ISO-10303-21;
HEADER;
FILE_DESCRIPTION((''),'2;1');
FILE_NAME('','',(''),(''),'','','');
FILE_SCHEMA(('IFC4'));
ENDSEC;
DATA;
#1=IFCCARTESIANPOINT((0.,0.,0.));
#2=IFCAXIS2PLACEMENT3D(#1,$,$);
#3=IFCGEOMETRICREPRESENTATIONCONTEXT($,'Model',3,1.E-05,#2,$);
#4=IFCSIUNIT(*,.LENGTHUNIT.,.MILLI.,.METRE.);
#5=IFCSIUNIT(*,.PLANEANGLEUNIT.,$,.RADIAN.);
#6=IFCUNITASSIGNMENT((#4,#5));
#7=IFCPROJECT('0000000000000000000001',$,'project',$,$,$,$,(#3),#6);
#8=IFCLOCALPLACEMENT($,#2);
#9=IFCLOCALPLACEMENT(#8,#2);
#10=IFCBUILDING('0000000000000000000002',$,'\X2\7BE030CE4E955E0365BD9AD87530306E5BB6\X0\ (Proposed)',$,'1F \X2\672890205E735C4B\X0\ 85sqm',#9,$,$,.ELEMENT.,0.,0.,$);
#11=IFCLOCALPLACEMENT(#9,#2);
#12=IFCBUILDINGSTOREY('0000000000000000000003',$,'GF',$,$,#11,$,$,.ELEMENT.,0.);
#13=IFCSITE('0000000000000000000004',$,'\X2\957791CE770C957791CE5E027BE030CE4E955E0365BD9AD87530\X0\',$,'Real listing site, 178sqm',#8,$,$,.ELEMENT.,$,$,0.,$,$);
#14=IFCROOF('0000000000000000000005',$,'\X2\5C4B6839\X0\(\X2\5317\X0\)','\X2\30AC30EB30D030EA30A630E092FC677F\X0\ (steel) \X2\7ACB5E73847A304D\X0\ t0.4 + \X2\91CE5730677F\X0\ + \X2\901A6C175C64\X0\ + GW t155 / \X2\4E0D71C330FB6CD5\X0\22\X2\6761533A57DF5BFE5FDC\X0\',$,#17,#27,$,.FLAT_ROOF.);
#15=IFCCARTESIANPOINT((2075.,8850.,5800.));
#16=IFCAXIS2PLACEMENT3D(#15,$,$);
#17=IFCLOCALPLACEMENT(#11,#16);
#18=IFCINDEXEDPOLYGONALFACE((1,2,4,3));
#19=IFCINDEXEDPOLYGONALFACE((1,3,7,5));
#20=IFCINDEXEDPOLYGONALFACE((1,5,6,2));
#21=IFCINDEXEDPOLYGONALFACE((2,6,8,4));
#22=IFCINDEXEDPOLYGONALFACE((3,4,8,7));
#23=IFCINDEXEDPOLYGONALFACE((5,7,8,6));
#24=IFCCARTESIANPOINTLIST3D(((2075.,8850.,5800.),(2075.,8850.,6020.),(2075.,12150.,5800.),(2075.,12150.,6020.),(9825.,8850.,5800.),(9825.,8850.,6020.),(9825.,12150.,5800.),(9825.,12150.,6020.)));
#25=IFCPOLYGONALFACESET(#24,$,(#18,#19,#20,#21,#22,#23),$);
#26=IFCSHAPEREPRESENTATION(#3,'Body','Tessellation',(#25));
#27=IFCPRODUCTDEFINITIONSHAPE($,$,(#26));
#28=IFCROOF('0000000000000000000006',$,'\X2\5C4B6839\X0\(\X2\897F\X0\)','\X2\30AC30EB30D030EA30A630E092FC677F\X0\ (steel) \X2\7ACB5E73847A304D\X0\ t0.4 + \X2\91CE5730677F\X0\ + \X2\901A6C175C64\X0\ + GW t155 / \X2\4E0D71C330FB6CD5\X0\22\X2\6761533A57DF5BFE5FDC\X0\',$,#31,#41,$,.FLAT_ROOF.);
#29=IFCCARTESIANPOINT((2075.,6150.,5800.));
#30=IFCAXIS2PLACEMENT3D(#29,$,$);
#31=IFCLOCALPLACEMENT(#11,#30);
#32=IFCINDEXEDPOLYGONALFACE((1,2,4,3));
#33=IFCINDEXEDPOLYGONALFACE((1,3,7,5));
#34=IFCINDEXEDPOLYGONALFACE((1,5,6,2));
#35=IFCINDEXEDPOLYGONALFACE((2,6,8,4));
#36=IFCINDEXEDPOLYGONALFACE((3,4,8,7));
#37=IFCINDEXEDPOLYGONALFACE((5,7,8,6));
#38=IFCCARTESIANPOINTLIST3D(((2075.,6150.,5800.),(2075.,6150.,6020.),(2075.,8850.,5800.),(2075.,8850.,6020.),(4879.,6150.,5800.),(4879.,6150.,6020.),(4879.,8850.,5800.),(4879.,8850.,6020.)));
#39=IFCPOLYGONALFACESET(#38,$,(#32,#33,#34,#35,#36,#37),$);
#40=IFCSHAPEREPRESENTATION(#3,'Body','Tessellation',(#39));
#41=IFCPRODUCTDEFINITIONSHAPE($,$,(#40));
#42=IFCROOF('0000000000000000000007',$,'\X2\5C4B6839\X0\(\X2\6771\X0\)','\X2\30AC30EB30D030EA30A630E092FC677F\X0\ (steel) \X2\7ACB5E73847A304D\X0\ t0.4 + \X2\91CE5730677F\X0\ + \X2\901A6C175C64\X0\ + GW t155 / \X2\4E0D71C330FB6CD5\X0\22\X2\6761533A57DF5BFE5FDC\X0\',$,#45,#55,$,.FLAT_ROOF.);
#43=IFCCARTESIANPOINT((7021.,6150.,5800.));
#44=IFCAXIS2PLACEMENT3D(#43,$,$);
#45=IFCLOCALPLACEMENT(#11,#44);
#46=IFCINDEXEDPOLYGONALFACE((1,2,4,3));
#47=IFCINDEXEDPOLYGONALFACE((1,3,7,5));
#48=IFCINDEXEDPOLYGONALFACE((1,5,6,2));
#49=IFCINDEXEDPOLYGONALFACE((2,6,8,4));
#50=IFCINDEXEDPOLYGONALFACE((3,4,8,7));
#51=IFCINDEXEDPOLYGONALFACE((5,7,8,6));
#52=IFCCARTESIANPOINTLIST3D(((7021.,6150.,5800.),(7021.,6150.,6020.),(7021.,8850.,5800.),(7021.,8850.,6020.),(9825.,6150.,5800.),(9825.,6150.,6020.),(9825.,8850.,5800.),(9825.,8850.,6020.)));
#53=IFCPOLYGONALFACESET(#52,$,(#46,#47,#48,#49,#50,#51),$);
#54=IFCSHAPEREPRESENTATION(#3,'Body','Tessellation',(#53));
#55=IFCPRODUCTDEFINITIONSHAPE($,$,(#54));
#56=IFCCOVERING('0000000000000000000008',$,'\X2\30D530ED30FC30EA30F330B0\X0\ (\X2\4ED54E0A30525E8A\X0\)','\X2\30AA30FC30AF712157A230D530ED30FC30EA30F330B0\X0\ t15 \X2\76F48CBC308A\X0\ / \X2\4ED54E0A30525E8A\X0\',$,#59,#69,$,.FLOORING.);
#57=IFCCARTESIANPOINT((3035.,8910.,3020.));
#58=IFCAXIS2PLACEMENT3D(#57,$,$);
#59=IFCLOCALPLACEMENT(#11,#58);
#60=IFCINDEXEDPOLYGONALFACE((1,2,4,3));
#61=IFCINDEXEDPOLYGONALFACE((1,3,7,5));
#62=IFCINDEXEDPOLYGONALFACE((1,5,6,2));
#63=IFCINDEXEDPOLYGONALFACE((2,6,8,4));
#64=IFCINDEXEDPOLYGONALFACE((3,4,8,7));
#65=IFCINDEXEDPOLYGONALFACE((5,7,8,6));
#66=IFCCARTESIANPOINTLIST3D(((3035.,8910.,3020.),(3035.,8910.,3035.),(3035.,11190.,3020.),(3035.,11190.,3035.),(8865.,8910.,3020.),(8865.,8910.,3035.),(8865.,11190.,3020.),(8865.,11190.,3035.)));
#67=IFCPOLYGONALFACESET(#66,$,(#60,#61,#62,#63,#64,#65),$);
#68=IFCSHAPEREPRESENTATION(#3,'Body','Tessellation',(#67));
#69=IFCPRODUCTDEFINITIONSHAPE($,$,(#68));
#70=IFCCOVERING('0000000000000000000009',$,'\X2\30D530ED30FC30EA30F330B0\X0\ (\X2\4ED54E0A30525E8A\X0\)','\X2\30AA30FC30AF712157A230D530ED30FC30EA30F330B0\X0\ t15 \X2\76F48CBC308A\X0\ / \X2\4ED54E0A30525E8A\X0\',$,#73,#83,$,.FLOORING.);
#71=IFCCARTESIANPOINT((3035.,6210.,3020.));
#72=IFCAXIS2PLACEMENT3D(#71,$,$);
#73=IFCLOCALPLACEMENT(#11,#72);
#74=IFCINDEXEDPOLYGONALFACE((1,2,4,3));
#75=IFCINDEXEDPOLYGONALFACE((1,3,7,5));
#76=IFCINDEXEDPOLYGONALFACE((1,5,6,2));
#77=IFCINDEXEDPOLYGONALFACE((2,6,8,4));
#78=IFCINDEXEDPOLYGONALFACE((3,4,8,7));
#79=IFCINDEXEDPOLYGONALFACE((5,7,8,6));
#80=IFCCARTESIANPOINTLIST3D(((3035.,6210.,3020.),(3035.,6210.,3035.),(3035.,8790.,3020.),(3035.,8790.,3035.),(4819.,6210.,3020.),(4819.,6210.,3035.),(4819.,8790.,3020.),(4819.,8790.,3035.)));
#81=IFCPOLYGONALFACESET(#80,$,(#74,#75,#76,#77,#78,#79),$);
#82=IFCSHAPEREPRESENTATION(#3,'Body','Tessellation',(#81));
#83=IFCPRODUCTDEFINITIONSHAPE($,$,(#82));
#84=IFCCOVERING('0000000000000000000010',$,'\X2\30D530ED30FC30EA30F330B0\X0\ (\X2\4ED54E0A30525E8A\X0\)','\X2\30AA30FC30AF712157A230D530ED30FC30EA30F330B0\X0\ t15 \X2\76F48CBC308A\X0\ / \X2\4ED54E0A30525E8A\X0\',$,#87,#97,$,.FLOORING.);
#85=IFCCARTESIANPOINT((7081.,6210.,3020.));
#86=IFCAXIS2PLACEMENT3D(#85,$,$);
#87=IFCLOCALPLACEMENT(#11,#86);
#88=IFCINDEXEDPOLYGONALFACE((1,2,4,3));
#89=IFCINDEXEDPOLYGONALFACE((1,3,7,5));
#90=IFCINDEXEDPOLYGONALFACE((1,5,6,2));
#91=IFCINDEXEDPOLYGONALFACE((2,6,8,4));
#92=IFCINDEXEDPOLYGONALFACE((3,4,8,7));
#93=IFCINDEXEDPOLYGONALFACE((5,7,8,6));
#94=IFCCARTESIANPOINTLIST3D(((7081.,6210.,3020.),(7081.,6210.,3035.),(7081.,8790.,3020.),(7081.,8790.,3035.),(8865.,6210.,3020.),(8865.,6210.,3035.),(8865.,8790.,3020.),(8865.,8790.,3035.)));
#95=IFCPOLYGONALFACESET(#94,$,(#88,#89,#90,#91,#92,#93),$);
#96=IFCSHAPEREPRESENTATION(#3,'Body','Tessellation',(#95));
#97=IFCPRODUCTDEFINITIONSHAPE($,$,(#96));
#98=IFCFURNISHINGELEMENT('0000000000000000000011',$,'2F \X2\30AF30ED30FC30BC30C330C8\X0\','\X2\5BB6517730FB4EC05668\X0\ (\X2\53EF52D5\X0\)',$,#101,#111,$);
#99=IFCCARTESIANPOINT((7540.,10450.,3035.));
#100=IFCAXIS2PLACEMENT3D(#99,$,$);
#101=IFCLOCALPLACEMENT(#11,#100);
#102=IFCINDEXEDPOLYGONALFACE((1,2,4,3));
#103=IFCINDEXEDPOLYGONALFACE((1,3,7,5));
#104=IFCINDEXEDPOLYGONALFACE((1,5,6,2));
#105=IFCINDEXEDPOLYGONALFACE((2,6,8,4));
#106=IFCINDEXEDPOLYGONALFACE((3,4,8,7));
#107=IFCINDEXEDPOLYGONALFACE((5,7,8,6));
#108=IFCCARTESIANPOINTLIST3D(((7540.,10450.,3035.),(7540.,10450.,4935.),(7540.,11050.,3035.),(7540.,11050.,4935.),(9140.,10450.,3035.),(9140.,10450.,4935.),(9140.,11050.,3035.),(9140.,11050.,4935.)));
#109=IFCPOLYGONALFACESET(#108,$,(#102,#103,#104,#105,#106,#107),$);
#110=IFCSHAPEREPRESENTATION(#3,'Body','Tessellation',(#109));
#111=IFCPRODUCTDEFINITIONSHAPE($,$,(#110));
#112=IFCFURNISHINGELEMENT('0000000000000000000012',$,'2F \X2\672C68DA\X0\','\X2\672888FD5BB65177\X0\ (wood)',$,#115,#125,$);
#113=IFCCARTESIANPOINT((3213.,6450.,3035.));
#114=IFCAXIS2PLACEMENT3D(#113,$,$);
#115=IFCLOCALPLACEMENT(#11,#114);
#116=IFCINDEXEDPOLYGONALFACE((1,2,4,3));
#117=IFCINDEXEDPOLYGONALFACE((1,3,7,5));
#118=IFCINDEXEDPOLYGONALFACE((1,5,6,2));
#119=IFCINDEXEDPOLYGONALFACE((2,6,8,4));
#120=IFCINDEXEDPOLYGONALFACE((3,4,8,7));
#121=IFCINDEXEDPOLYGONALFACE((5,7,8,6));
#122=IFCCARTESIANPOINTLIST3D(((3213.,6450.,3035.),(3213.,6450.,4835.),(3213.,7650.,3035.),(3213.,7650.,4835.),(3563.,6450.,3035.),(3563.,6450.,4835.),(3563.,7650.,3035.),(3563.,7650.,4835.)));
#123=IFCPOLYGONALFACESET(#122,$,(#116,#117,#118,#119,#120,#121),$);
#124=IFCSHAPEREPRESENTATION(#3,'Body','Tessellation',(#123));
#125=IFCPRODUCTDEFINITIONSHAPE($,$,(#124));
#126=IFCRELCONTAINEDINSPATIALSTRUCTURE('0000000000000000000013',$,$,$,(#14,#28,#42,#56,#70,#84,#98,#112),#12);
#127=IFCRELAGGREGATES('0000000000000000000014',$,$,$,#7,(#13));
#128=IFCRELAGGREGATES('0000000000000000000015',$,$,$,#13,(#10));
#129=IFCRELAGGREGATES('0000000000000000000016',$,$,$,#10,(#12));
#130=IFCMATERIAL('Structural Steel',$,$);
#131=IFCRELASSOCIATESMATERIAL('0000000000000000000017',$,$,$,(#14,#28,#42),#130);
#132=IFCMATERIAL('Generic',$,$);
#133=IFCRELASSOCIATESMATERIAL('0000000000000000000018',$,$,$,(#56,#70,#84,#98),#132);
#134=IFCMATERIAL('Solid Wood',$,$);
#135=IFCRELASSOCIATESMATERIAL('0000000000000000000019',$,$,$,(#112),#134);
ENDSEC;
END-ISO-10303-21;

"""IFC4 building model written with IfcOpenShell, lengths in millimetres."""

from ifc_helpers import new_model, si_unit, frame, frame_2d, origin, place, context, project, spatial, rectangle, extrude, material, element, save


model = new_model("IFC4")

# Units and contexts
model_context = context("Model", 3, precision=1e-05, world=origin())
ifc_project = project(units=[si_unit("LENGTHUNIT", "METRE", prefix="MILLI"), si_unit("PLANEANGLEUNIT", "RADIAN")], contexts=[model_context])

# Site, building, storey
site_placement = place(None, origin())
site = spatial("IfcSite", under=ifc_project, at=site_placement, Name="長野県長野市篠ノ井布施高田", ObjectType="Real listing site, 178sqm", CompositionType="ELEMENT", RefElevation=0.0)
building_placement = place(site_placement, origin())
building = spatial("IfcBuilding", under=site, at=building_placement, Name="篠ノ井布施高田の家 (Proposed)", ObjectType="1F 木造平屋 85sqm", CompositionType="ELEMENT", ElevationOfRefHeight=0.0, ElevationOfTerrain=0.0)
storey_placement = place(building_placement, origin())
storey = spatial("IfcBuildingStorey", under=building, at=storey_placement, Name="GF", CompositionType="ELEMENT", Elevation=0.0)

# Shared definitions
ifc_material_1 = material(Name="Solid Wood")

# Shared definitions
ifc_material_2 = material(Name="Generic")

# Roofs
ifc_material_3 = material(Name="Structural Steel")
for number, where, name in (
    (1, (2075.0, 8850.0, 5800.0), "屋根(北)"),
):
    element("IfcRoof", number, at=place(storey_placement, frame(where)), inside=storey, material=ifc_material_3, Name=name, Description="ガルバリウム鋼板 (steel) 立平葺き t0.4 + 野地板 + 通気層 + GW t155 / 不燃・法22条区域対応", PredefinedType="FLAT_ROOF", context=model_context, shape_type="SweptSolid", body=[
        extrude(rectangle(XDim=7750.0, YDim=3300.0, at=frame_2d((3875.0, 1650.0))), frame((2075.0, 8850.0, 5800.0)), (0.0, 0.0, 1.0), 220.0),
    ])
roof_1_placement = place(storey_placement, frame((2075.0, 6150.0, 5800.0)))
element("IfcRoof", 2, at=roof_1_placement, inside=storey, material=ifc_material_3, Name="屋根(西)", Description="ガルバリウム鋼板 (steel) 立平葺き t0.4 + 野地板 + 通気層 + GW t155 / 不燃・法22条区域対応", PredefinedType="FLAT_ROOF", context=model_context, shape_type="SweptSolid", body=[
    extrude(rectangle(XDim=2804.0, YDim=2700.0, at=frame_2d((1402.0, 1350.0))), frame((2075.0, 6150.0, 5800.0)), (0.0, 0.0, 1.0), 220.0),
])
roof_2_placement = place(storey_placement, frame((7021.0, 6150.0, 5800.0)))
element("IfcRoof", 3, at=roof_2_placement, inside=storey, material=ifc_material_3, Name="屋根(東)", Description="ガルバリウム鋼板 (steel) 立平葺き t0.4 + 野地板 + 通気層 + GW t155 / 不燃・法22条区域対応", PredefinedType="FLAT_ROOF", context=model_context, shape_type="SweptSolid", body=[
    extrude(rectangle(XDim=2804.0, YDim=2700.0, at=frame_2d((1402.0, 1350.0))), frame((7021.0, 6150.0, 5800.0)), (0.0, 0.0, 1.0), 220.0),
])

# Coverings
covering_1_placement = place(storey_placement, frame((3035.0, 8910.0, 3020.0)))
element("IfcCovering", 4, at=covering_1_placement, inside=storey, material=ifc_material_2, Name="フローリング (仕上げ床)", Description="オーク無垢フローリング t15 直貼り / 仕上げ床", PredefinedType="FLOORING", context=model_context, shape_type="SweptSolid", body=[
    extrude(rectangle(XDim=5830.0, YDim=2280.0, at=frame_2d((2915.0, 1140.0))), frame((3035.0, 8910.0, 3020.0)), (0.0, 0.0, 1.0), 15.0),
])
covering_2_placement = place(storey_placement, frame((3035.0, 6210.0, 3020.0)))
element("IfcCovering", 5, at=covering_2_placement, inside=storey, material=ifc_material_2, Name="フローリング (仕上げ床)", Description="オーク無垢フローリング t15 直貼り / 仕上げ床", PredefinedType="FLOORING", context=model_context, shape_type="SweptSolid", body=[
    extrude(rectangle(XDim=1784.0, YDim=2580.0, at=frame_2d((892.0, 1290.0))), frame((3035.0, 6210.0, 3020.0)), (0.0, 0.0, 1.0), 15.0),
])
covering_3_placement = place(storey_placement, frame((7081.0, 6210.0, 3020.0)))
element("IfcCovering", 6, at=covering_3_placement, inside=storey, material=ifc_material_2, Name="フローリング (仕上げ床)", Description="オーク無垢フローリング t15 直貼り / 仕上げ床", PredefinedType="FLOORING", context=model_context, shape_type="SweptSolid", body=[
    extrude(rectangle(XDim=1784.0, YDim=2580.0, at=frame_2d((892.0, 1290.0))), frame((7081.0, 6210.0, 3020.0)), (0.0, 0.0, 1.0), 15.0),
])

# Furnishing elements
furnishing_1_placement = place(storey_placement, frame((7540.0, 10450.0, 3035.0)))
element("IfcFurnishingElement", 7, at=furnishing_1_placement, inside=storey, material=ifc_material_2, Name="2F クローゼット", Description="家具・什器 (可動)", context=model_context, shape_type="SweptSolid", body=[
    extrude(rectangle(XDim=1600.0, YDim=600.0, at=frame_2d((800.0, 300.0))), frame((7540.0, 10450.0, 3035.0)), (0.0, 0.0, 1.0), 1900.0),
])
furnishing_2_placement = place(storey_placement, frame((3213.0, 6450.0, 3035.0)))
element("IfcFurnishingElement", 8, at=furnishing_2_placement, inside=storey, material=ifc_material_1, Name="2F 本棚", Description="木製家具 (wood)", context=model_context, shape_type="SweptSolid", body=[
    extrude(rectangle(XDim=350.0, YDim=1200.0, at=frame_2d((175.0, 600.0))), frame((3213.0, 6450.0, 3035.0)), (0.0, 0.0, 1.0), 1800.0),
])

save(model, "model.ifc")
